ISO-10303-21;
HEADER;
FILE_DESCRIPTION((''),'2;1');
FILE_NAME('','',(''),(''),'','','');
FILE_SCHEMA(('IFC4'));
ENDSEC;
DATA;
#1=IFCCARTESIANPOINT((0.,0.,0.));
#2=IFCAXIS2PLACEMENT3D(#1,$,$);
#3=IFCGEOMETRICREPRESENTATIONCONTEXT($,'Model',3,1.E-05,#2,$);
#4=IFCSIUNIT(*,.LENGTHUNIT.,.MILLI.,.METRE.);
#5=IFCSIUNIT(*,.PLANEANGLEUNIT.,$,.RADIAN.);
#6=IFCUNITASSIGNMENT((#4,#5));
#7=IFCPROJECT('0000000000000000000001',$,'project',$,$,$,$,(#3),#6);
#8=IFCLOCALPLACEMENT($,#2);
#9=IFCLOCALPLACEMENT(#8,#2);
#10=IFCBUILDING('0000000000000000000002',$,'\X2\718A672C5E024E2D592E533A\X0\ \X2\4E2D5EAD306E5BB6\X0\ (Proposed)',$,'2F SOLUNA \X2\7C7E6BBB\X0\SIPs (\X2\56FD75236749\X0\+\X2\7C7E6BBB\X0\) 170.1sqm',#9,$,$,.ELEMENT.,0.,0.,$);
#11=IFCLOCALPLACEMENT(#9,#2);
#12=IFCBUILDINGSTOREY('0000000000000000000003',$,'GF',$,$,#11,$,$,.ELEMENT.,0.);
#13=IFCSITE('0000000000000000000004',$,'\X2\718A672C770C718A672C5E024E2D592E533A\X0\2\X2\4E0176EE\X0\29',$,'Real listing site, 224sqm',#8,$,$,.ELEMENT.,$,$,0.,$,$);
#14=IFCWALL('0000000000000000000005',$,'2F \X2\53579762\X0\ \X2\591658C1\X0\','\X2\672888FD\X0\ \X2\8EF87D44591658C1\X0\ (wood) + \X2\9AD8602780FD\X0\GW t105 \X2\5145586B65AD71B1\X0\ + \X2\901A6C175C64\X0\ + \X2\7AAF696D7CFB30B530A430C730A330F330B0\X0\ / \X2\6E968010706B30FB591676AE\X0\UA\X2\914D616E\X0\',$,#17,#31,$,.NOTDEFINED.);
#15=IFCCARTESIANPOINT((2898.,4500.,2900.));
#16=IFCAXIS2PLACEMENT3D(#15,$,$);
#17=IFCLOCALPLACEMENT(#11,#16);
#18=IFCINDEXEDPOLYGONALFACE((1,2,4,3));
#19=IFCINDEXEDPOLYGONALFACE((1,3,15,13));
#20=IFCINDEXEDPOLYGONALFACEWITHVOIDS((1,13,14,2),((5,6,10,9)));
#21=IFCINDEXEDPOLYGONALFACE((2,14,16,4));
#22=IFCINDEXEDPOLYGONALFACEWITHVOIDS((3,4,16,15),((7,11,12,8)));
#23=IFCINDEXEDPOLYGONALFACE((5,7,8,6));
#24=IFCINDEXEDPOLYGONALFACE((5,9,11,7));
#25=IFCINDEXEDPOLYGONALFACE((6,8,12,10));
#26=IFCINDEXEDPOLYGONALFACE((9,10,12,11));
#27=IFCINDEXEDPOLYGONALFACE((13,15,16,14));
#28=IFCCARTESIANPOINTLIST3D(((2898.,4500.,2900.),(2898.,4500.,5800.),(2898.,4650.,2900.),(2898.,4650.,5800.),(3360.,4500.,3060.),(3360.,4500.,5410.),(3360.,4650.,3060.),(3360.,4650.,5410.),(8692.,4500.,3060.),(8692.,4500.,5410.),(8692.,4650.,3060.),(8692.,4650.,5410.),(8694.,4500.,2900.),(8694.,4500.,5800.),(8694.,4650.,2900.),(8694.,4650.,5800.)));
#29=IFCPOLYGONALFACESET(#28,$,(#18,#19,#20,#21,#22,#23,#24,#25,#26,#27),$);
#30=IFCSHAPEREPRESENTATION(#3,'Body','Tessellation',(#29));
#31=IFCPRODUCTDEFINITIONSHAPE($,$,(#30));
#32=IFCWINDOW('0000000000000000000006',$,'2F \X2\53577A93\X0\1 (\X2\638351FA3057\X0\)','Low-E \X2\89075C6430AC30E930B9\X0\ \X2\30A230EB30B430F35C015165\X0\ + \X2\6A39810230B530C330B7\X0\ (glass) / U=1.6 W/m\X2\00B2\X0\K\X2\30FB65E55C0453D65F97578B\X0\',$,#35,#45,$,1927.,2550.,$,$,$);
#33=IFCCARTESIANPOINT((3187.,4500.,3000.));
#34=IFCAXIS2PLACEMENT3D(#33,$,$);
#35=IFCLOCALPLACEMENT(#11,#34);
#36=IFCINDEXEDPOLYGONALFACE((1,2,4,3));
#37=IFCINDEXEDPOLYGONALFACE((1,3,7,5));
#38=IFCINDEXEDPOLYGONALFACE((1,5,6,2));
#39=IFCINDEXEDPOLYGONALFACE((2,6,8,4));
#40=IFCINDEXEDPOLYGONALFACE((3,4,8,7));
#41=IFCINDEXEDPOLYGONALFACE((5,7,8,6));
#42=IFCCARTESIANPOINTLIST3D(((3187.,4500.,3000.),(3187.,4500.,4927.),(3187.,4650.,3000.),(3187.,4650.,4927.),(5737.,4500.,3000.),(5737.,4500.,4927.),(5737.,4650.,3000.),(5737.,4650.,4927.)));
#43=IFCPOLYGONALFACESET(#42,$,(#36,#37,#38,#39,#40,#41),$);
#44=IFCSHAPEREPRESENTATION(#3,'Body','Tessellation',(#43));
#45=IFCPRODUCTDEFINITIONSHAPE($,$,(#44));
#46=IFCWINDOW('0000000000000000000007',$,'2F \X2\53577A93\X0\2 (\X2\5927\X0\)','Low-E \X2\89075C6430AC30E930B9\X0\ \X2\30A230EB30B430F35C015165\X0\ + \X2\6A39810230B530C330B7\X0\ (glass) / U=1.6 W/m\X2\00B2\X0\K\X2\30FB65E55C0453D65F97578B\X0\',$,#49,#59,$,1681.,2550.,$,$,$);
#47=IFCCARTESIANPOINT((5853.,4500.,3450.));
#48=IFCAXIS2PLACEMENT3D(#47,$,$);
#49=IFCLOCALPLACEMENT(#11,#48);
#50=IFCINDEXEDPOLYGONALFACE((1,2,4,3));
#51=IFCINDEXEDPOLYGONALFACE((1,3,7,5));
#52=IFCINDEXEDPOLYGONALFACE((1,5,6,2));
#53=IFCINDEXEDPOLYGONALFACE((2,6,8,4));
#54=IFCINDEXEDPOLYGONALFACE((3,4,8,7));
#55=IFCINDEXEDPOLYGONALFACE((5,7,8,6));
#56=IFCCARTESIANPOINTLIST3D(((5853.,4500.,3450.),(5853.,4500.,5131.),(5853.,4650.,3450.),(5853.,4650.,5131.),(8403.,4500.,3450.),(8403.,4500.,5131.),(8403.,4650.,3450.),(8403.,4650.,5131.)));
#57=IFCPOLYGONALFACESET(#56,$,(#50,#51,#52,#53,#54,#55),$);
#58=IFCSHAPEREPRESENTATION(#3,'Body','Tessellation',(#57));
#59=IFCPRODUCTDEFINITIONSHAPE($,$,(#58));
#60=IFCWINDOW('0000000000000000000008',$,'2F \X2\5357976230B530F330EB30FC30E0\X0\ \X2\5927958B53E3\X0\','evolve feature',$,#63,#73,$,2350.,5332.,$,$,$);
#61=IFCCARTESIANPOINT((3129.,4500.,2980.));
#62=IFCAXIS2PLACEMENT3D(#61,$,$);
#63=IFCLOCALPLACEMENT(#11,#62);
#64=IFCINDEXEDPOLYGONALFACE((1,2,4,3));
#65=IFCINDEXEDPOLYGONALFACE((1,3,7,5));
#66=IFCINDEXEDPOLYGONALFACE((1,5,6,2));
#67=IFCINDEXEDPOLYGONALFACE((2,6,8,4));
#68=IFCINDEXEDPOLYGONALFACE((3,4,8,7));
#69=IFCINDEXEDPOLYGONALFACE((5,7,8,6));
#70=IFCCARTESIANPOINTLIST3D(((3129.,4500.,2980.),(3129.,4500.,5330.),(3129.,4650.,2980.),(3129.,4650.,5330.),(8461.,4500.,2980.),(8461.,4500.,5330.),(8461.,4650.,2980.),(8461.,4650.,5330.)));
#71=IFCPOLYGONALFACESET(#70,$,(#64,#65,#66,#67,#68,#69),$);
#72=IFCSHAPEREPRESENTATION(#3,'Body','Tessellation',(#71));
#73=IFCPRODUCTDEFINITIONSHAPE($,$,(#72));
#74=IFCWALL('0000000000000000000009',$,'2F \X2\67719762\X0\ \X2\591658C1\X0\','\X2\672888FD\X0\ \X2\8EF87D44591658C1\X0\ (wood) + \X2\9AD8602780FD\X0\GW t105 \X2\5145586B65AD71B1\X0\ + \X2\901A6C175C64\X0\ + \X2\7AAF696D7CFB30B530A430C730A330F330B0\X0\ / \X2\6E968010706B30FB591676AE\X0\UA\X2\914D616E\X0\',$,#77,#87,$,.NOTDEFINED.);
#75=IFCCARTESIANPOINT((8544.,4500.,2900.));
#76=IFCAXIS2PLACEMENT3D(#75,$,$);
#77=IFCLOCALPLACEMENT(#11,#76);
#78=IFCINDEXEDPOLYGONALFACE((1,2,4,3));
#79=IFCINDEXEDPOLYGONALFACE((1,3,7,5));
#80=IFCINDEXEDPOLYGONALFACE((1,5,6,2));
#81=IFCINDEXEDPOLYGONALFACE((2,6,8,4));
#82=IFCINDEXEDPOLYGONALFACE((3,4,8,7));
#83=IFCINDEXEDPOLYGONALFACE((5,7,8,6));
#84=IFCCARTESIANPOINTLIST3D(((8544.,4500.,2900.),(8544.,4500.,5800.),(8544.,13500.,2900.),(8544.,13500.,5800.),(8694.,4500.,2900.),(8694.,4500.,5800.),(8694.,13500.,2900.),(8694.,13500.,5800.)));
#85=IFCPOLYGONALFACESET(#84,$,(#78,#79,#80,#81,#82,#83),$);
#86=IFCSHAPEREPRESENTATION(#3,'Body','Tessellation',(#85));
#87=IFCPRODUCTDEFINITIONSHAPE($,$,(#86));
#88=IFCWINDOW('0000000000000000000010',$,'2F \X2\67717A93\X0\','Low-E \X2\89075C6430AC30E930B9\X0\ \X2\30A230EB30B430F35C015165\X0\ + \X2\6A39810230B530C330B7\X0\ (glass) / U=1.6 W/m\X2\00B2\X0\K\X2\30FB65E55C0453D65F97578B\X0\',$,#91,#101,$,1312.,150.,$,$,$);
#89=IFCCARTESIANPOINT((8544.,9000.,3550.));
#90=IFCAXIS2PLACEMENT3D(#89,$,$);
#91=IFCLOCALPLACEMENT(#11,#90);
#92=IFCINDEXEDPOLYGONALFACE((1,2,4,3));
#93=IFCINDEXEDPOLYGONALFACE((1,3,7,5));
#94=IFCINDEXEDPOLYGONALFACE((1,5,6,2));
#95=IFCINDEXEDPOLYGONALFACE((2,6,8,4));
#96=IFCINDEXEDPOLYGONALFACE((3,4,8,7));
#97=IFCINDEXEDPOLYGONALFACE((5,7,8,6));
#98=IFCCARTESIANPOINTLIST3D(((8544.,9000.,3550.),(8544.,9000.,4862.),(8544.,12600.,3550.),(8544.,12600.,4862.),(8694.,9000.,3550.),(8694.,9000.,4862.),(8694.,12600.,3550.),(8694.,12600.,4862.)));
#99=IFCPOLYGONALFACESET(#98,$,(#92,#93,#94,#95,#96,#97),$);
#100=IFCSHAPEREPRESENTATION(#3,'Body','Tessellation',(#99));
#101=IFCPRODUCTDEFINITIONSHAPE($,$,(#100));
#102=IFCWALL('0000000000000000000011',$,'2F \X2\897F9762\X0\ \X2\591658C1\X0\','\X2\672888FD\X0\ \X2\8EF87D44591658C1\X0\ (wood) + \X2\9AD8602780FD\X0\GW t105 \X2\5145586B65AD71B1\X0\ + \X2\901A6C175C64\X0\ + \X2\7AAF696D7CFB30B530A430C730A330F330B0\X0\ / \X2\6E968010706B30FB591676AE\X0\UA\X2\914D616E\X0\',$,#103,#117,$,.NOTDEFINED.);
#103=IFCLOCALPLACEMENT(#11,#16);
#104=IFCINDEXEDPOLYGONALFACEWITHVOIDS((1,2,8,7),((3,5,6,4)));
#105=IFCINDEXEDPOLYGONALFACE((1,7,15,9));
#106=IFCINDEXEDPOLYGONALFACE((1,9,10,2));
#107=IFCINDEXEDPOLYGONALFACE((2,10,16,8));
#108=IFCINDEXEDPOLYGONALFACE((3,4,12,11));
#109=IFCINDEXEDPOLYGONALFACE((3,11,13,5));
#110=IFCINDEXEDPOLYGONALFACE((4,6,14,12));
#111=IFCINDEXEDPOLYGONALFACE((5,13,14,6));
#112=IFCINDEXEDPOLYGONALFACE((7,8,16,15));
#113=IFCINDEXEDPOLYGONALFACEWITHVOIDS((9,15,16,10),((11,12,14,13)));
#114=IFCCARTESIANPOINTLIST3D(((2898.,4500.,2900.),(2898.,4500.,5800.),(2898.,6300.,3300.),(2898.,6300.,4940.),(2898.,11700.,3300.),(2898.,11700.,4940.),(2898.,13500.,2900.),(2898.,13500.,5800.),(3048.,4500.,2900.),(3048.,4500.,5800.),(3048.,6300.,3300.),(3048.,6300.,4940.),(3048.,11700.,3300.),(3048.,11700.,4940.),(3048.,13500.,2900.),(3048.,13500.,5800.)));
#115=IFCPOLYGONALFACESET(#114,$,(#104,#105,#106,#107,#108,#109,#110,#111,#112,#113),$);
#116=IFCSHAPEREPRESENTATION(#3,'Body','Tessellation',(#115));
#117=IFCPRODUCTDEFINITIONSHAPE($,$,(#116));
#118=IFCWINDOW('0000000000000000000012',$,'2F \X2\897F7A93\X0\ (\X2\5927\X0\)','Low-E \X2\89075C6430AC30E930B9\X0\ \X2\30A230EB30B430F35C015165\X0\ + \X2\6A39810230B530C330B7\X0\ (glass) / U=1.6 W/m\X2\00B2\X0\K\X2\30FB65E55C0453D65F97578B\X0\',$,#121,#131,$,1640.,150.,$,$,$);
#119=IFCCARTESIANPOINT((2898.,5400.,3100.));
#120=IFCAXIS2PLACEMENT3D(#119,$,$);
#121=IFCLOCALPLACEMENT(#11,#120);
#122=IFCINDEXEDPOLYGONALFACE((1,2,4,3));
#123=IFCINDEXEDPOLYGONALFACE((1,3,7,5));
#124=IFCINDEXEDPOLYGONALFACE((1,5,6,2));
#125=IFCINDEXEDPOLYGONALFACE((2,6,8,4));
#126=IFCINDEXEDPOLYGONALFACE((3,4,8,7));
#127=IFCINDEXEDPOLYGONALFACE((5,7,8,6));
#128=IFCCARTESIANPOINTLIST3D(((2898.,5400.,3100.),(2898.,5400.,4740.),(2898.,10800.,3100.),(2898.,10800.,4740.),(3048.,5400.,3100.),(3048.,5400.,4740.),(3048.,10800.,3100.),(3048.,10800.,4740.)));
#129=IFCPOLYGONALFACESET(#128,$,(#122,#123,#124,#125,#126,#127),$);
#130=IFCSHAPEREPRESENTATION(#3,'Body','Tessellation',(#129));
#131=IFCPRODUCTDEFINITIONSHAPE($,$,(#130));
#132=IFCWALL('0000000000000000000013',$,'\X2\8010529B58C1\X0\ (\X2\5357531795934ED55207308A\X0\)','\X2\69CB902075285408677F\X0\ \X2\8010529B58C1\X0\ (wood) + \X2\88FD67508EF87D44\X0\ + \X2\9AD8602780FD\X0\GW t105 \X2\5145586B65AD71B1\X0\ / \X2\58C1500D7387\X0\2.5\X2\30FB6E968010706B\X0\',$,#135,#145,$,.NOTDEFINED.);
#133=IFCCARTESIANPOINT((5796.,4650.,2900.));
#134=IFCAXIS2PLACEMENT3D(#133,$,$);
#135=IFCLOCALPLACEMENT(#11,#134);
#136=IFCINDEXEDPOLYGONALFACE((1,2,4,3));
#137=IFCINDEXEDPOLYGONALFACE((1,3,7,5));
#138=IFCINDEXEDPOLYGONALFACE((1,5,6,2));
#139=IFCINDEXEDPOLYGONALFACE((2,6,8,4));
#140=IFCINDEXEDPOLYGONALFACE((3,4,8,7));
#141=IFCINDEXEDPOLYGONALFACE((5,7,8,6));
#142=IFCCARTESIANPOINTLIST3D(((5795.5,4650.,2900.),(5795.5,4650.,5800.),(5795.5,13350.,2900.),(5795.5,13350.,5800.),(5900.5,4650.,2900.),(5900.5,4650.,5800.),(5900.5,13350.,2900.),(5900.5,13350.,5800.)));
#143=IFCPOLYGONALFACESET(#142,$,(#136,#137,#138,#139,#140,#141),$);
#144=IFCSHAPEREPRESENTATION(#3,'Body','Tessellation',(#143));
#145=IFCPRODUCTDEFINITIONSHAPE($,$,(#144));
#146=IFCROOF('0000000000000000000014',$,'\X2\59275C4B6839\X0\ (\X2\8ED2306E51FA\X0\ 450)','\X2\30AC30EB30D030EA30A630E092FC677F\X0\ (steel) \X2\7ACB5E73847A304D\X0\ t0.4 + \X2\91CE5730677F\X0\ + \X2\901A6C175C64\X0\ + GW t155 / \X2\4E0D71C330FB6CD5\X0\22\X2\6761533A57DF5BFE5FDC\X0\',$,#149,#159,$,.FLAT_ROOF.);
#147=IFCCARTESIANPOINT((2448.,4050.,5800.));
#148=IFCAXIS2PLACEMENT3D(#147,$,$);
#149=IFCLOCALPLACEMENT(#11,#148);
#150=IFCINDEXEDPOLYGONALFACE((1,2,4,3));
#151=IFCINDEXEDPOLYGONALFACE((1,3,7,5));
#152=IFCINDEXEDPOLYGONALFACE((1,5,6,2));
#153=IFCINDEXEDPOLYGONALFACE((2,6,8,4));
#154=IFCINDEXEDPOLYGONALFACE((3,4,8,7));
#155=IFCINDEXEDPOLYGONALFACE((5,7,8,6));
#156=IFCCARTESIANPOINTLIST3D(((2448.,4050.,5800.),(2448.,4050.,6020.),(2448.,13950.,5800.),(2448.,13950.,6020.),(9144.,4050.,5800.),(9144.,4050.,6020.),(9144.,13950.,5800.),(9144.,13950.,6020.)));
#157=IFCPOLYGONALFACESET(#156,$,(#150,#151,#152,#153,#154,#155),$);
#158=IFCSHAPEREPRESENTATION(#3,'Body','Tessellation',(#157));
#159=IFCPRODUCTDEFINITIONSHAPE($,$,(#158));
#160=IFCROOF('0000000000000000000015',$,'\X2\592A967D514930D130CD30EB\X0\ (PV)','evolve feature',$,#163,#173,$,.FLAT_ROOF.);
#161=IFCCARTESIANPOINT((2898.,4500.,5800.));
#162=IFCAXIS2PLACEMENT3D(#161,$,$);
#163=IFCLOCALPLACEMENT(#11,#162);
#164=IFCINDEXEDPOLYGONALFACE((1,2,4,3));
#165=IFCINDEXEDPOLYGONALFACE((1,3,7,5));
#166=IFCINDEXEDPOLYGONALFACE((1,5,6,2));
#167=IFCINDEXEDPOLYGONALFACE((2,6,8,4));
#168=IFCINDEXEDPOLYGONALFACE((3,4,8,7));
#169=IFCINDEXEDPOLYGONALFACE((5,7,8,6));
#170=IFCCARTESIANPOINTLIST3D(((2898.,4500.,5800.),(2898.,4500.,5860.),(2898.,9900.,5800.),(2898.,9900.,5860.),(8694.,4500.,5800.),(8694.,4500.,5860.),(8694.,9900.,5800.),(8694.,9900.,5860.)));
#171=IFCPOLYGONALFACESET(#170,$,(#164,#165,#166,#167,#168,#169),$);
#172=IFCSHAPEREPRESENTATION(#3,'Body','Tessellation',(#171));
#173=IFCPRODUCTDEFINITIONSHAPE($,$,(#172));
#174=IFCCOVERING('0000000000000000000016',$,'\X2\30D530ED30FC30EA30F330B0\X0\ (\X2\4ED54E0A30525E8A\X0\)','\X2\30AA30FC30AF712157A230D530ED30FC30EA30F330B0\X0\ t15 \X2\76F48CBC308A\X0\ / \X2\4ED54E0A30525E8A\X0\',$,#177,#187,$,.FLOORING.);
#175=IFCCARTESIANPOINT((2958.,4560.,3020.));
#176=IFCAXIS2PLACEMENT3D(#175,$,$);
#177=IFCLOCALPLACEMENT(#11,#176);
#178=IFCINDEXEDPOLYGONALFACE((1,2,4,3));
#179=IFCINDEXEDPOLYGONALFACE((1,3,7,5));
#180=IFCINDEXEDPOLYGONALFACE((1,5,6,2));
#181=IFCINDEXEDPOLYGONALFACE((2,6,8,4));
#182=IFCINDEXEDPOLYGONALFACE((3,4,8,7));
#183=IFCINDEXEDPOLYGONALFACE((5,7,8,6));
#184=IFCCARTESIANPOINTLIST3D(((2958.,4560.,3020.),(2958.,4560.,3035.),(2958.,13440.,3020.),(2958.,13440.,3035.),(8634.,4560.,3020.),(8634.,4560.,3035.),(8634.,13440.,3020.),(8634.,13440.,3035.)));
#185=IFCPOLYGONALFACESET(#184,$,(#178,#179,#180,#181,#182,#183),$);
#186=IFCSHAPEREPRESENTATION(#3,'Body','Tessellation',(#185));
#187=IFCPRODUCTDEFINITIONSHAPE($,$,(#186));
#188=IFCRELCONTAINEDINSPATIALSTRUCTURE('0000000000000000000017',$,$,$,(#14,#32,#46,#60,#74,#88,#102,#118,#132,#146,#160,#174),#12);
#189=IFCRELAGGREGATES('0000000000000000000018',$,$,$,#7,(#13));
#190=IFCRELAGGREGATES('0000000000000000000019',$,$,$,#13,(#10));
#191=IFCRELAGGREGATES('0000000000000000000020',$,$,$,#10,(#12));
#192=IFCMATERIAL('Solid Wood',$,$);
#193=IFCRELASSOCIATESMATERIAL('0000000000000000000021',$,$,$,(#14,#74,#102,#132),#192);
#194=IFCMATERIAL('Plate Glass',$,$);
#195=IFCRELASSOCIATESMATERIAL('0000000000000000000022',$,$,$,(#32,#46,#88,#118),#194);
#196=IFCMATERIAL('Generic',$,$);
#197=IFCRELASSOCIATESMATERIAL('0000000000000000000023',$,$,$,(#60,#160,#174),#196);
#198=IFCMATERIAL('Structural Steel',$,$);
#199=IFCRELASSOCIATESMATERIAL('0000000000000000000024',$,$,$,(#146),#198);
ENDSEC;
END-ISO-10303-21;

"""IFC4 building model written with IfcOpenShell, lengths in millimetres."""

from ifc_helpers import new_model, si_unit, frame, frame_2d, origin, place, context, project, spatial, rectangle, extrude, material, element, fill, save


model = new_model("IFC4")

# Units and contexts
model_context = context("Model", 3, precision=1e-05, world=origin())
ifc_project = project(units=[si_unit("LENGTHUNIT", "METRE", prefix="MILLI"), si_unit("PLANEANGLEUNIT", "RADIAN")], contexts=[model_context])

# Site, building, storey
site_placement = place(None, origin())
site = spatial("IfcSite", under=ifc_project, at=site_placement, Name="熊本県熊本市中央区2丁目29", ObjectType="Real listing site, 224sqm", CompositionType="ELEMENT", RefElevation=0.0)
building_placement = place(site_placement, origin())
building = spatial("IfcBuilding", under=site, at=building_placement, Name="熊本市中央区 中庭の家 (Proposed)", ObjectType="2F SOLUNA 籾殻SIPs (国産杉+籾殻) 170.1sqm", CompositionType="ELEMENT", ElevationOfRefHeight=0.0, ElevationOfTerrain=0.0)
storey_placement = place(building_placement, origin())
storey = spatial("IfcBuildingStorey", under=building, at=storey_placement, Name="GF", CompositionType="ELEMENT", Elevation=0.0)

# Shared definitions
ifc_material_1 = material(Name="Solid Wood")

# Wall, openings, windows
wall_1_placement = place(storey_placement, frame((2898.0, 4500.0, 2900.0)))
wall_1 = element("IfcWall", 1, at=wall_1_placement, inside=storey, material=ifc_material_1, Name="2F 南面 外壁", Description="木製 軸組外壁 (wood) + 高性能GW t105 充填断熱 + 通気層 + 窯業系サイディング / 準耐火・外皮UA配慮", PredefinedType="NOTDEFINED", context=model_context, shape_type="SweptSolid", body=[
    extrude(rectangle(XDim=5796.0, YDim=150.0, at=frame_2d((2898.0, 75.0))), frame((2898.0, 4500.0, 2900.0)), (0.0, 0.0, 1.0), 2900.0),
])
opening_1_placement = place(storey_placement, frame((3187.0, 4500.0, 3000.0)))
opening_1 = element("IfcOpeningElement", 2, at=opening_1_placement, cuts=wall_1, PredefinedType="NOTDEFINED", context=model_context, shape_type="SweptSolid", body=[
    extrude(rectangle(XDim=2550.0, YDim=150.0, at=frame_2d((1275.0, 75.0))), frame((3187.0, 4500.0, 3000.0)), (0.0, 0.0, 1.0), 1927.0),
])
opening_2_placement = place(storey_placement, frame((5853.0, 4500.0, 3450.0)))
opening_2 = element("IfcOpeningElement", 3, at=opening_2_placement, cuts=wall_1, PredefinedType="NOTDEFINED", context=model_context, shape_type="SweptSolid", body=[
    extrude(rectangle(XDim=2550.0, YDim=150.0, at=frame_2d((1275.0, 75.0))), frame((5853.0, 4500.0, 3450.0)), (0.0, 0.0, 1.0), 1681.0),
])
opening_3_placement = place(storey_placement, frame((3129.0, 4500.0, 2980.0)))
opening_3 = element("IfcOpeningElement", 4, at=opening_3_placement, cuts=wall_1, PredefinedType="NOTDEFINED", context=model_context, shape_type="SweptSolid", body=[
    extrude(rectangle(XDim=5332.0, YDim=150.0, at=frame_2d((2666.0, 75.0))), frame((3129.0, 4500.0, 2980.0)), (0.0, 0.0, 1.0), 2350.0),
])
ifc_material_2 = material(Name="Plate Glass")
window_1_placement = place(storey_placement, frame((3187.0, 4500.0, 3000.0)))
window_1 = element("IfcWindow", 5, at=window_1_placement, inside=storey, material=ifc_material_2, Name="2F 南窓1 (掃出し)", Description="Low-E 複層ガラス アルゴン封入 + 樹脂サッシ (glass) / U=1.6 W/m²K・日射取得型", OverallHeight=1927.0, OverallWidth=2550.0, context=model_context, shape_type="SweptSolid", body=[
    extrude(rectangle(XDim=2550.0, YDim=150.0, at=frame_2d((1275.0, 75.0))), frame((3187.0, 4500.0, 3000.0)), (0.0, 0.0, 1.0), 1927.0),
])
fill(opening_1, window_1)
window_2_placement = place(storey_placement, frame((5853.0, 4500.0, 3450.0)))
window_2 = element("IfcWindow", 6, at=window_2_placement, inside=storey, material=ifc_material_2, Name="2F 南窓2 (大)", Description="Low-E 複層ガラス アルゴン封入 + 樹脂サッシ (glass) / U=1.6 W/m²K・日射取得型", OverallHeight=1681.0, OverallWidth=2550.0, context=model_context, shape_type="SweptSolid", body=[
    extrude(rectangle(XDim=2550.0, YDim=150.0, at=frame_2d((1275.0, 75.0))), frame((5853.0, 4500.0, 3450.0)), (0.0, 0.0, 1.0), 1681.0),
])
fill(opening_2, window_2)
ifc_material_3 = material(Name="Generic")
window_3_placement = place(storey_placement, frame((3129.0, 4500.0, 2980.0)))
window_3 = element("IfcWindow", 7, at=window_3_placement, inside=storey, material=ifc_material_3, Name="2F 南面サンルーム 大開口", Description="evolve feature", OverallHeight=2350.0, OverallWidth=5332.0, context=model_context, shape_type="SweptSolid", body=[
    extrude(rectangle(XDim=5332.0, YDim=150.0, at=frame_2d((2666.0, 75.0))), frame((3129.0, 4500.0, 2980.0)), (0.0, 0.0, 1.0), 2350.0),
])
fill(opening_3, window_3)

# Walls, openings, windows
wall_2_placement = place(storey_placement, frame((8544.0, 4500.0, 2900.0)))
wall_2 = element("IfcWall", 8, at=wall_2_placement, inside=storey, material=ifc_material_1, Name="2F 東面 外壁", Description="木製 軸組外壁 (wood) + 高性能GW t105 充填断熱 + 通気層 + 窯業系サイディング / 準耐火・外皮UA配慮", PredefinedType="NOTDEFINED", context=model_context, shape_type="SweptSolid", body=[
    extrude(rectangle(XDim=150.0, YDim=9000.0, at=frame_2d((75.0, 4500.0))), frame((8544.0, 4500.0, 2900.0)), (0.0, 0.0, 1.0), 2900.0),
])
opening_4_placement = place(storey_placement, frame((8544.0, 9000.0, 3550.0)))
opening_4 = element("IfcOpeningElement", 9, at=opening_4_placement, cuts=wall_2, PredefinedType="NOTDEFINED", context=model_context, shape_type="SweptSolid", body=[
    extrude(rectangle(XDim=150.0, YDim=3600.0, at=frame_2d((75.0, 1800.0))), frame((8544.0, 9000.0, 3550.0)), (0.0, 0.0, 1.0), 1312.0),
])
window_4_placement = place(storey_placement, frame((8544.0, 9000.0, 3550.0)))
window_4 = element("IfcWindow", 10, at=window_4_placement, inside=storey, material=ifc_material_2, Name="2F 東窓", Description="Low-E 複層ガラス アルゴン封入 + 樹脂サッシ (glass) / U=1.6 W/m²K・日射取得型", OverallHeight=1312.0, OverallWidth=150.0, context=model_context, shape_type="SweptSolid", body=[
    extrude(rectangle(XDim=150.0, YDim=3600.0, at=frame_2d((75.0, 1800.0))), frame((8544.0, 9000.0, 3550.0)), (0.0, 0.0, 1.0), 1312.0),
])
fill(opening_4, window_4)
wall_3_placement = place(storey_placement, frame((2898.0, 4500.0, 2900.0)))
wall_3 = element("IfcWall", 11, at=wall_3_placement, inside=storey, material=ifc_material_1, Name="2F 西面 外壁", Description="木製 軸組外壁 (wood) + 高性能GW t105 充填断熱 + 通気層 + 窯業系サイディング / 準耐火・外皮UA配慮", PredefinedType="NOTDEFINED", context=model_context, shape_type="SweptSolid", body=[
    extrude(rectangle(XDim=150.0, YDim=9000.0, at=frame_2d((75.0, 4500.0))), frame((2898.0, 4500.0, 2900.0)), (0.0, 0.0, 1.0), 2900.0),
])
opening_5_placement = place(storey_placement, frame((2898.0, 5400.0, 3100.0)))
opening_5 = element("IfcOpeningElement", 12, at=opening_5_placement, cuts=wall_3, PredefinedType="NOTDEFINED", context=model_context, shape_type="SweptSolid", body=[
    extrude(rectangle(XDim=150.0, YDim=5400.0, at=frame_2d((75.0, 2700.0))), frame((2898.0, 5400.0, 3100.0)), (0.0, 0.0, 1.0), 1640.0),
])
window_5_placement = place(storey_placement, frame((2898.0, 5400.0, 3100.0)))
window_5 = element("IfcWindow", 13, at=window_5_placement, inside=storey, material=ifc_material_2, Name="2F 西窓 (大)", Description="Low-E 複層ガラス アルゴン封入 + 樹脂サッシ (glass) / U=1.6 W/m²K・日射取得型", OverallHeight=1640.0, OverallWidth=150.0, context=model_context, shape_type="SweptSolid", body=[
    extrude(rectangle(XDim=150.0, YDim=5400.0, at=frame_2d((75.0, 2700.0))), frame((2898.0, 5400.0, 3100.0)), (0.0, 0.0, 1.0), 1640.0),
])
fill(opening_5, window_5)

# Wall
wall_4_placement = place(storey_placement, frame((5796.0, 4650.0, 2900.0)))
element("IfcWall", 14, at=wall_4_placement, inside=storey, material=ifc_material_1, Name="耐力壁 (南北間仕切り)", Description="構造用合板 耐力壁 (wood) + 製材軸組 + 高性能GW t105 充填断熱 / 壁倍率2.5・準耐火", PredefinedType="NOTDEFINED", context=model_context, shape_type="SweptSolid", body=[
    extrude(rectangle(XDim=105.0, YDim=8700.0, at=frame_2d((52.0, 4350.0))), frame((5796.0, 4650.0, 2900.0)), (0.0, 0.0, 1.0), 2900.0),
])

# Roofs
ifc_material_4 = material(Name="Structural Steel")
roof_1_placement = place(storey_placement, frame((2448.0, 4050.0, 5800.0)))
element("IfcRoof", 15, at=roof_1_placement, inside=storey, material=ifc_material_4, Name="大屋根 (軒の出 450)", Description="ガルバリウム鋼板 (steel) 立平葺き t0.4 + 野地板 + 通気層 + GW t155 / 不燃・法22条区域対応", PredefinedType="FLAT_ROOF", context=model_context, shape_type="SweptSolid", body=[
    extrude(rectangle(XDim=6696.0, YDim=9900.0, at=frame_2d((3348.0, 4950.0))), frame((2448.0, 4050.0, 5800.0)), (0.0, 0.0, 1.0), 220.0),
])
roof_2_placement = place(storey_placement, frame((2898.0, 4500.0, 5800.0)))
element("IfcRoof", 16, at=roof_2_placement, inside=storey, material=ifc_material_3, Name="太陽光パネル (PV)", Description="evolve feature", PredefinedType="FLAT_ROOF", context=model_context, shape_type="SweptSolid", body=[
    extrude(rectangle(XDim=5796.0, YDim=5400.0, at=frame_2d((2898.0, 2700.0))), frame((2898.0, 4500.0, 5800.0)), (0.0, 0.0, 1.0), 60.0),
])

# Covering
covering_placement = place(storey_placement, frame((2958.0, 4560.0, 3020.0)))
element("IfcCovering", 17, at=covering_placement, inside=storey, material=ifc_material_3, Name="フローリング (仕上げ床)", Description="オーク無垢フローリング t15 直貼り / 仕上げ床", PredefinedType="FLOORING", context=model_context, shape_type="SweptSolid", body=[
    extrude(rectangle(XDim=5676.0, YDim=8880.0, at=frame_2d((2838.0, 4440.0))), frame((2958.0, 4560.0, 3020.0)), (0.0, 0.0, 1.0), 15.0),
])

save(model, "model.ifc")
